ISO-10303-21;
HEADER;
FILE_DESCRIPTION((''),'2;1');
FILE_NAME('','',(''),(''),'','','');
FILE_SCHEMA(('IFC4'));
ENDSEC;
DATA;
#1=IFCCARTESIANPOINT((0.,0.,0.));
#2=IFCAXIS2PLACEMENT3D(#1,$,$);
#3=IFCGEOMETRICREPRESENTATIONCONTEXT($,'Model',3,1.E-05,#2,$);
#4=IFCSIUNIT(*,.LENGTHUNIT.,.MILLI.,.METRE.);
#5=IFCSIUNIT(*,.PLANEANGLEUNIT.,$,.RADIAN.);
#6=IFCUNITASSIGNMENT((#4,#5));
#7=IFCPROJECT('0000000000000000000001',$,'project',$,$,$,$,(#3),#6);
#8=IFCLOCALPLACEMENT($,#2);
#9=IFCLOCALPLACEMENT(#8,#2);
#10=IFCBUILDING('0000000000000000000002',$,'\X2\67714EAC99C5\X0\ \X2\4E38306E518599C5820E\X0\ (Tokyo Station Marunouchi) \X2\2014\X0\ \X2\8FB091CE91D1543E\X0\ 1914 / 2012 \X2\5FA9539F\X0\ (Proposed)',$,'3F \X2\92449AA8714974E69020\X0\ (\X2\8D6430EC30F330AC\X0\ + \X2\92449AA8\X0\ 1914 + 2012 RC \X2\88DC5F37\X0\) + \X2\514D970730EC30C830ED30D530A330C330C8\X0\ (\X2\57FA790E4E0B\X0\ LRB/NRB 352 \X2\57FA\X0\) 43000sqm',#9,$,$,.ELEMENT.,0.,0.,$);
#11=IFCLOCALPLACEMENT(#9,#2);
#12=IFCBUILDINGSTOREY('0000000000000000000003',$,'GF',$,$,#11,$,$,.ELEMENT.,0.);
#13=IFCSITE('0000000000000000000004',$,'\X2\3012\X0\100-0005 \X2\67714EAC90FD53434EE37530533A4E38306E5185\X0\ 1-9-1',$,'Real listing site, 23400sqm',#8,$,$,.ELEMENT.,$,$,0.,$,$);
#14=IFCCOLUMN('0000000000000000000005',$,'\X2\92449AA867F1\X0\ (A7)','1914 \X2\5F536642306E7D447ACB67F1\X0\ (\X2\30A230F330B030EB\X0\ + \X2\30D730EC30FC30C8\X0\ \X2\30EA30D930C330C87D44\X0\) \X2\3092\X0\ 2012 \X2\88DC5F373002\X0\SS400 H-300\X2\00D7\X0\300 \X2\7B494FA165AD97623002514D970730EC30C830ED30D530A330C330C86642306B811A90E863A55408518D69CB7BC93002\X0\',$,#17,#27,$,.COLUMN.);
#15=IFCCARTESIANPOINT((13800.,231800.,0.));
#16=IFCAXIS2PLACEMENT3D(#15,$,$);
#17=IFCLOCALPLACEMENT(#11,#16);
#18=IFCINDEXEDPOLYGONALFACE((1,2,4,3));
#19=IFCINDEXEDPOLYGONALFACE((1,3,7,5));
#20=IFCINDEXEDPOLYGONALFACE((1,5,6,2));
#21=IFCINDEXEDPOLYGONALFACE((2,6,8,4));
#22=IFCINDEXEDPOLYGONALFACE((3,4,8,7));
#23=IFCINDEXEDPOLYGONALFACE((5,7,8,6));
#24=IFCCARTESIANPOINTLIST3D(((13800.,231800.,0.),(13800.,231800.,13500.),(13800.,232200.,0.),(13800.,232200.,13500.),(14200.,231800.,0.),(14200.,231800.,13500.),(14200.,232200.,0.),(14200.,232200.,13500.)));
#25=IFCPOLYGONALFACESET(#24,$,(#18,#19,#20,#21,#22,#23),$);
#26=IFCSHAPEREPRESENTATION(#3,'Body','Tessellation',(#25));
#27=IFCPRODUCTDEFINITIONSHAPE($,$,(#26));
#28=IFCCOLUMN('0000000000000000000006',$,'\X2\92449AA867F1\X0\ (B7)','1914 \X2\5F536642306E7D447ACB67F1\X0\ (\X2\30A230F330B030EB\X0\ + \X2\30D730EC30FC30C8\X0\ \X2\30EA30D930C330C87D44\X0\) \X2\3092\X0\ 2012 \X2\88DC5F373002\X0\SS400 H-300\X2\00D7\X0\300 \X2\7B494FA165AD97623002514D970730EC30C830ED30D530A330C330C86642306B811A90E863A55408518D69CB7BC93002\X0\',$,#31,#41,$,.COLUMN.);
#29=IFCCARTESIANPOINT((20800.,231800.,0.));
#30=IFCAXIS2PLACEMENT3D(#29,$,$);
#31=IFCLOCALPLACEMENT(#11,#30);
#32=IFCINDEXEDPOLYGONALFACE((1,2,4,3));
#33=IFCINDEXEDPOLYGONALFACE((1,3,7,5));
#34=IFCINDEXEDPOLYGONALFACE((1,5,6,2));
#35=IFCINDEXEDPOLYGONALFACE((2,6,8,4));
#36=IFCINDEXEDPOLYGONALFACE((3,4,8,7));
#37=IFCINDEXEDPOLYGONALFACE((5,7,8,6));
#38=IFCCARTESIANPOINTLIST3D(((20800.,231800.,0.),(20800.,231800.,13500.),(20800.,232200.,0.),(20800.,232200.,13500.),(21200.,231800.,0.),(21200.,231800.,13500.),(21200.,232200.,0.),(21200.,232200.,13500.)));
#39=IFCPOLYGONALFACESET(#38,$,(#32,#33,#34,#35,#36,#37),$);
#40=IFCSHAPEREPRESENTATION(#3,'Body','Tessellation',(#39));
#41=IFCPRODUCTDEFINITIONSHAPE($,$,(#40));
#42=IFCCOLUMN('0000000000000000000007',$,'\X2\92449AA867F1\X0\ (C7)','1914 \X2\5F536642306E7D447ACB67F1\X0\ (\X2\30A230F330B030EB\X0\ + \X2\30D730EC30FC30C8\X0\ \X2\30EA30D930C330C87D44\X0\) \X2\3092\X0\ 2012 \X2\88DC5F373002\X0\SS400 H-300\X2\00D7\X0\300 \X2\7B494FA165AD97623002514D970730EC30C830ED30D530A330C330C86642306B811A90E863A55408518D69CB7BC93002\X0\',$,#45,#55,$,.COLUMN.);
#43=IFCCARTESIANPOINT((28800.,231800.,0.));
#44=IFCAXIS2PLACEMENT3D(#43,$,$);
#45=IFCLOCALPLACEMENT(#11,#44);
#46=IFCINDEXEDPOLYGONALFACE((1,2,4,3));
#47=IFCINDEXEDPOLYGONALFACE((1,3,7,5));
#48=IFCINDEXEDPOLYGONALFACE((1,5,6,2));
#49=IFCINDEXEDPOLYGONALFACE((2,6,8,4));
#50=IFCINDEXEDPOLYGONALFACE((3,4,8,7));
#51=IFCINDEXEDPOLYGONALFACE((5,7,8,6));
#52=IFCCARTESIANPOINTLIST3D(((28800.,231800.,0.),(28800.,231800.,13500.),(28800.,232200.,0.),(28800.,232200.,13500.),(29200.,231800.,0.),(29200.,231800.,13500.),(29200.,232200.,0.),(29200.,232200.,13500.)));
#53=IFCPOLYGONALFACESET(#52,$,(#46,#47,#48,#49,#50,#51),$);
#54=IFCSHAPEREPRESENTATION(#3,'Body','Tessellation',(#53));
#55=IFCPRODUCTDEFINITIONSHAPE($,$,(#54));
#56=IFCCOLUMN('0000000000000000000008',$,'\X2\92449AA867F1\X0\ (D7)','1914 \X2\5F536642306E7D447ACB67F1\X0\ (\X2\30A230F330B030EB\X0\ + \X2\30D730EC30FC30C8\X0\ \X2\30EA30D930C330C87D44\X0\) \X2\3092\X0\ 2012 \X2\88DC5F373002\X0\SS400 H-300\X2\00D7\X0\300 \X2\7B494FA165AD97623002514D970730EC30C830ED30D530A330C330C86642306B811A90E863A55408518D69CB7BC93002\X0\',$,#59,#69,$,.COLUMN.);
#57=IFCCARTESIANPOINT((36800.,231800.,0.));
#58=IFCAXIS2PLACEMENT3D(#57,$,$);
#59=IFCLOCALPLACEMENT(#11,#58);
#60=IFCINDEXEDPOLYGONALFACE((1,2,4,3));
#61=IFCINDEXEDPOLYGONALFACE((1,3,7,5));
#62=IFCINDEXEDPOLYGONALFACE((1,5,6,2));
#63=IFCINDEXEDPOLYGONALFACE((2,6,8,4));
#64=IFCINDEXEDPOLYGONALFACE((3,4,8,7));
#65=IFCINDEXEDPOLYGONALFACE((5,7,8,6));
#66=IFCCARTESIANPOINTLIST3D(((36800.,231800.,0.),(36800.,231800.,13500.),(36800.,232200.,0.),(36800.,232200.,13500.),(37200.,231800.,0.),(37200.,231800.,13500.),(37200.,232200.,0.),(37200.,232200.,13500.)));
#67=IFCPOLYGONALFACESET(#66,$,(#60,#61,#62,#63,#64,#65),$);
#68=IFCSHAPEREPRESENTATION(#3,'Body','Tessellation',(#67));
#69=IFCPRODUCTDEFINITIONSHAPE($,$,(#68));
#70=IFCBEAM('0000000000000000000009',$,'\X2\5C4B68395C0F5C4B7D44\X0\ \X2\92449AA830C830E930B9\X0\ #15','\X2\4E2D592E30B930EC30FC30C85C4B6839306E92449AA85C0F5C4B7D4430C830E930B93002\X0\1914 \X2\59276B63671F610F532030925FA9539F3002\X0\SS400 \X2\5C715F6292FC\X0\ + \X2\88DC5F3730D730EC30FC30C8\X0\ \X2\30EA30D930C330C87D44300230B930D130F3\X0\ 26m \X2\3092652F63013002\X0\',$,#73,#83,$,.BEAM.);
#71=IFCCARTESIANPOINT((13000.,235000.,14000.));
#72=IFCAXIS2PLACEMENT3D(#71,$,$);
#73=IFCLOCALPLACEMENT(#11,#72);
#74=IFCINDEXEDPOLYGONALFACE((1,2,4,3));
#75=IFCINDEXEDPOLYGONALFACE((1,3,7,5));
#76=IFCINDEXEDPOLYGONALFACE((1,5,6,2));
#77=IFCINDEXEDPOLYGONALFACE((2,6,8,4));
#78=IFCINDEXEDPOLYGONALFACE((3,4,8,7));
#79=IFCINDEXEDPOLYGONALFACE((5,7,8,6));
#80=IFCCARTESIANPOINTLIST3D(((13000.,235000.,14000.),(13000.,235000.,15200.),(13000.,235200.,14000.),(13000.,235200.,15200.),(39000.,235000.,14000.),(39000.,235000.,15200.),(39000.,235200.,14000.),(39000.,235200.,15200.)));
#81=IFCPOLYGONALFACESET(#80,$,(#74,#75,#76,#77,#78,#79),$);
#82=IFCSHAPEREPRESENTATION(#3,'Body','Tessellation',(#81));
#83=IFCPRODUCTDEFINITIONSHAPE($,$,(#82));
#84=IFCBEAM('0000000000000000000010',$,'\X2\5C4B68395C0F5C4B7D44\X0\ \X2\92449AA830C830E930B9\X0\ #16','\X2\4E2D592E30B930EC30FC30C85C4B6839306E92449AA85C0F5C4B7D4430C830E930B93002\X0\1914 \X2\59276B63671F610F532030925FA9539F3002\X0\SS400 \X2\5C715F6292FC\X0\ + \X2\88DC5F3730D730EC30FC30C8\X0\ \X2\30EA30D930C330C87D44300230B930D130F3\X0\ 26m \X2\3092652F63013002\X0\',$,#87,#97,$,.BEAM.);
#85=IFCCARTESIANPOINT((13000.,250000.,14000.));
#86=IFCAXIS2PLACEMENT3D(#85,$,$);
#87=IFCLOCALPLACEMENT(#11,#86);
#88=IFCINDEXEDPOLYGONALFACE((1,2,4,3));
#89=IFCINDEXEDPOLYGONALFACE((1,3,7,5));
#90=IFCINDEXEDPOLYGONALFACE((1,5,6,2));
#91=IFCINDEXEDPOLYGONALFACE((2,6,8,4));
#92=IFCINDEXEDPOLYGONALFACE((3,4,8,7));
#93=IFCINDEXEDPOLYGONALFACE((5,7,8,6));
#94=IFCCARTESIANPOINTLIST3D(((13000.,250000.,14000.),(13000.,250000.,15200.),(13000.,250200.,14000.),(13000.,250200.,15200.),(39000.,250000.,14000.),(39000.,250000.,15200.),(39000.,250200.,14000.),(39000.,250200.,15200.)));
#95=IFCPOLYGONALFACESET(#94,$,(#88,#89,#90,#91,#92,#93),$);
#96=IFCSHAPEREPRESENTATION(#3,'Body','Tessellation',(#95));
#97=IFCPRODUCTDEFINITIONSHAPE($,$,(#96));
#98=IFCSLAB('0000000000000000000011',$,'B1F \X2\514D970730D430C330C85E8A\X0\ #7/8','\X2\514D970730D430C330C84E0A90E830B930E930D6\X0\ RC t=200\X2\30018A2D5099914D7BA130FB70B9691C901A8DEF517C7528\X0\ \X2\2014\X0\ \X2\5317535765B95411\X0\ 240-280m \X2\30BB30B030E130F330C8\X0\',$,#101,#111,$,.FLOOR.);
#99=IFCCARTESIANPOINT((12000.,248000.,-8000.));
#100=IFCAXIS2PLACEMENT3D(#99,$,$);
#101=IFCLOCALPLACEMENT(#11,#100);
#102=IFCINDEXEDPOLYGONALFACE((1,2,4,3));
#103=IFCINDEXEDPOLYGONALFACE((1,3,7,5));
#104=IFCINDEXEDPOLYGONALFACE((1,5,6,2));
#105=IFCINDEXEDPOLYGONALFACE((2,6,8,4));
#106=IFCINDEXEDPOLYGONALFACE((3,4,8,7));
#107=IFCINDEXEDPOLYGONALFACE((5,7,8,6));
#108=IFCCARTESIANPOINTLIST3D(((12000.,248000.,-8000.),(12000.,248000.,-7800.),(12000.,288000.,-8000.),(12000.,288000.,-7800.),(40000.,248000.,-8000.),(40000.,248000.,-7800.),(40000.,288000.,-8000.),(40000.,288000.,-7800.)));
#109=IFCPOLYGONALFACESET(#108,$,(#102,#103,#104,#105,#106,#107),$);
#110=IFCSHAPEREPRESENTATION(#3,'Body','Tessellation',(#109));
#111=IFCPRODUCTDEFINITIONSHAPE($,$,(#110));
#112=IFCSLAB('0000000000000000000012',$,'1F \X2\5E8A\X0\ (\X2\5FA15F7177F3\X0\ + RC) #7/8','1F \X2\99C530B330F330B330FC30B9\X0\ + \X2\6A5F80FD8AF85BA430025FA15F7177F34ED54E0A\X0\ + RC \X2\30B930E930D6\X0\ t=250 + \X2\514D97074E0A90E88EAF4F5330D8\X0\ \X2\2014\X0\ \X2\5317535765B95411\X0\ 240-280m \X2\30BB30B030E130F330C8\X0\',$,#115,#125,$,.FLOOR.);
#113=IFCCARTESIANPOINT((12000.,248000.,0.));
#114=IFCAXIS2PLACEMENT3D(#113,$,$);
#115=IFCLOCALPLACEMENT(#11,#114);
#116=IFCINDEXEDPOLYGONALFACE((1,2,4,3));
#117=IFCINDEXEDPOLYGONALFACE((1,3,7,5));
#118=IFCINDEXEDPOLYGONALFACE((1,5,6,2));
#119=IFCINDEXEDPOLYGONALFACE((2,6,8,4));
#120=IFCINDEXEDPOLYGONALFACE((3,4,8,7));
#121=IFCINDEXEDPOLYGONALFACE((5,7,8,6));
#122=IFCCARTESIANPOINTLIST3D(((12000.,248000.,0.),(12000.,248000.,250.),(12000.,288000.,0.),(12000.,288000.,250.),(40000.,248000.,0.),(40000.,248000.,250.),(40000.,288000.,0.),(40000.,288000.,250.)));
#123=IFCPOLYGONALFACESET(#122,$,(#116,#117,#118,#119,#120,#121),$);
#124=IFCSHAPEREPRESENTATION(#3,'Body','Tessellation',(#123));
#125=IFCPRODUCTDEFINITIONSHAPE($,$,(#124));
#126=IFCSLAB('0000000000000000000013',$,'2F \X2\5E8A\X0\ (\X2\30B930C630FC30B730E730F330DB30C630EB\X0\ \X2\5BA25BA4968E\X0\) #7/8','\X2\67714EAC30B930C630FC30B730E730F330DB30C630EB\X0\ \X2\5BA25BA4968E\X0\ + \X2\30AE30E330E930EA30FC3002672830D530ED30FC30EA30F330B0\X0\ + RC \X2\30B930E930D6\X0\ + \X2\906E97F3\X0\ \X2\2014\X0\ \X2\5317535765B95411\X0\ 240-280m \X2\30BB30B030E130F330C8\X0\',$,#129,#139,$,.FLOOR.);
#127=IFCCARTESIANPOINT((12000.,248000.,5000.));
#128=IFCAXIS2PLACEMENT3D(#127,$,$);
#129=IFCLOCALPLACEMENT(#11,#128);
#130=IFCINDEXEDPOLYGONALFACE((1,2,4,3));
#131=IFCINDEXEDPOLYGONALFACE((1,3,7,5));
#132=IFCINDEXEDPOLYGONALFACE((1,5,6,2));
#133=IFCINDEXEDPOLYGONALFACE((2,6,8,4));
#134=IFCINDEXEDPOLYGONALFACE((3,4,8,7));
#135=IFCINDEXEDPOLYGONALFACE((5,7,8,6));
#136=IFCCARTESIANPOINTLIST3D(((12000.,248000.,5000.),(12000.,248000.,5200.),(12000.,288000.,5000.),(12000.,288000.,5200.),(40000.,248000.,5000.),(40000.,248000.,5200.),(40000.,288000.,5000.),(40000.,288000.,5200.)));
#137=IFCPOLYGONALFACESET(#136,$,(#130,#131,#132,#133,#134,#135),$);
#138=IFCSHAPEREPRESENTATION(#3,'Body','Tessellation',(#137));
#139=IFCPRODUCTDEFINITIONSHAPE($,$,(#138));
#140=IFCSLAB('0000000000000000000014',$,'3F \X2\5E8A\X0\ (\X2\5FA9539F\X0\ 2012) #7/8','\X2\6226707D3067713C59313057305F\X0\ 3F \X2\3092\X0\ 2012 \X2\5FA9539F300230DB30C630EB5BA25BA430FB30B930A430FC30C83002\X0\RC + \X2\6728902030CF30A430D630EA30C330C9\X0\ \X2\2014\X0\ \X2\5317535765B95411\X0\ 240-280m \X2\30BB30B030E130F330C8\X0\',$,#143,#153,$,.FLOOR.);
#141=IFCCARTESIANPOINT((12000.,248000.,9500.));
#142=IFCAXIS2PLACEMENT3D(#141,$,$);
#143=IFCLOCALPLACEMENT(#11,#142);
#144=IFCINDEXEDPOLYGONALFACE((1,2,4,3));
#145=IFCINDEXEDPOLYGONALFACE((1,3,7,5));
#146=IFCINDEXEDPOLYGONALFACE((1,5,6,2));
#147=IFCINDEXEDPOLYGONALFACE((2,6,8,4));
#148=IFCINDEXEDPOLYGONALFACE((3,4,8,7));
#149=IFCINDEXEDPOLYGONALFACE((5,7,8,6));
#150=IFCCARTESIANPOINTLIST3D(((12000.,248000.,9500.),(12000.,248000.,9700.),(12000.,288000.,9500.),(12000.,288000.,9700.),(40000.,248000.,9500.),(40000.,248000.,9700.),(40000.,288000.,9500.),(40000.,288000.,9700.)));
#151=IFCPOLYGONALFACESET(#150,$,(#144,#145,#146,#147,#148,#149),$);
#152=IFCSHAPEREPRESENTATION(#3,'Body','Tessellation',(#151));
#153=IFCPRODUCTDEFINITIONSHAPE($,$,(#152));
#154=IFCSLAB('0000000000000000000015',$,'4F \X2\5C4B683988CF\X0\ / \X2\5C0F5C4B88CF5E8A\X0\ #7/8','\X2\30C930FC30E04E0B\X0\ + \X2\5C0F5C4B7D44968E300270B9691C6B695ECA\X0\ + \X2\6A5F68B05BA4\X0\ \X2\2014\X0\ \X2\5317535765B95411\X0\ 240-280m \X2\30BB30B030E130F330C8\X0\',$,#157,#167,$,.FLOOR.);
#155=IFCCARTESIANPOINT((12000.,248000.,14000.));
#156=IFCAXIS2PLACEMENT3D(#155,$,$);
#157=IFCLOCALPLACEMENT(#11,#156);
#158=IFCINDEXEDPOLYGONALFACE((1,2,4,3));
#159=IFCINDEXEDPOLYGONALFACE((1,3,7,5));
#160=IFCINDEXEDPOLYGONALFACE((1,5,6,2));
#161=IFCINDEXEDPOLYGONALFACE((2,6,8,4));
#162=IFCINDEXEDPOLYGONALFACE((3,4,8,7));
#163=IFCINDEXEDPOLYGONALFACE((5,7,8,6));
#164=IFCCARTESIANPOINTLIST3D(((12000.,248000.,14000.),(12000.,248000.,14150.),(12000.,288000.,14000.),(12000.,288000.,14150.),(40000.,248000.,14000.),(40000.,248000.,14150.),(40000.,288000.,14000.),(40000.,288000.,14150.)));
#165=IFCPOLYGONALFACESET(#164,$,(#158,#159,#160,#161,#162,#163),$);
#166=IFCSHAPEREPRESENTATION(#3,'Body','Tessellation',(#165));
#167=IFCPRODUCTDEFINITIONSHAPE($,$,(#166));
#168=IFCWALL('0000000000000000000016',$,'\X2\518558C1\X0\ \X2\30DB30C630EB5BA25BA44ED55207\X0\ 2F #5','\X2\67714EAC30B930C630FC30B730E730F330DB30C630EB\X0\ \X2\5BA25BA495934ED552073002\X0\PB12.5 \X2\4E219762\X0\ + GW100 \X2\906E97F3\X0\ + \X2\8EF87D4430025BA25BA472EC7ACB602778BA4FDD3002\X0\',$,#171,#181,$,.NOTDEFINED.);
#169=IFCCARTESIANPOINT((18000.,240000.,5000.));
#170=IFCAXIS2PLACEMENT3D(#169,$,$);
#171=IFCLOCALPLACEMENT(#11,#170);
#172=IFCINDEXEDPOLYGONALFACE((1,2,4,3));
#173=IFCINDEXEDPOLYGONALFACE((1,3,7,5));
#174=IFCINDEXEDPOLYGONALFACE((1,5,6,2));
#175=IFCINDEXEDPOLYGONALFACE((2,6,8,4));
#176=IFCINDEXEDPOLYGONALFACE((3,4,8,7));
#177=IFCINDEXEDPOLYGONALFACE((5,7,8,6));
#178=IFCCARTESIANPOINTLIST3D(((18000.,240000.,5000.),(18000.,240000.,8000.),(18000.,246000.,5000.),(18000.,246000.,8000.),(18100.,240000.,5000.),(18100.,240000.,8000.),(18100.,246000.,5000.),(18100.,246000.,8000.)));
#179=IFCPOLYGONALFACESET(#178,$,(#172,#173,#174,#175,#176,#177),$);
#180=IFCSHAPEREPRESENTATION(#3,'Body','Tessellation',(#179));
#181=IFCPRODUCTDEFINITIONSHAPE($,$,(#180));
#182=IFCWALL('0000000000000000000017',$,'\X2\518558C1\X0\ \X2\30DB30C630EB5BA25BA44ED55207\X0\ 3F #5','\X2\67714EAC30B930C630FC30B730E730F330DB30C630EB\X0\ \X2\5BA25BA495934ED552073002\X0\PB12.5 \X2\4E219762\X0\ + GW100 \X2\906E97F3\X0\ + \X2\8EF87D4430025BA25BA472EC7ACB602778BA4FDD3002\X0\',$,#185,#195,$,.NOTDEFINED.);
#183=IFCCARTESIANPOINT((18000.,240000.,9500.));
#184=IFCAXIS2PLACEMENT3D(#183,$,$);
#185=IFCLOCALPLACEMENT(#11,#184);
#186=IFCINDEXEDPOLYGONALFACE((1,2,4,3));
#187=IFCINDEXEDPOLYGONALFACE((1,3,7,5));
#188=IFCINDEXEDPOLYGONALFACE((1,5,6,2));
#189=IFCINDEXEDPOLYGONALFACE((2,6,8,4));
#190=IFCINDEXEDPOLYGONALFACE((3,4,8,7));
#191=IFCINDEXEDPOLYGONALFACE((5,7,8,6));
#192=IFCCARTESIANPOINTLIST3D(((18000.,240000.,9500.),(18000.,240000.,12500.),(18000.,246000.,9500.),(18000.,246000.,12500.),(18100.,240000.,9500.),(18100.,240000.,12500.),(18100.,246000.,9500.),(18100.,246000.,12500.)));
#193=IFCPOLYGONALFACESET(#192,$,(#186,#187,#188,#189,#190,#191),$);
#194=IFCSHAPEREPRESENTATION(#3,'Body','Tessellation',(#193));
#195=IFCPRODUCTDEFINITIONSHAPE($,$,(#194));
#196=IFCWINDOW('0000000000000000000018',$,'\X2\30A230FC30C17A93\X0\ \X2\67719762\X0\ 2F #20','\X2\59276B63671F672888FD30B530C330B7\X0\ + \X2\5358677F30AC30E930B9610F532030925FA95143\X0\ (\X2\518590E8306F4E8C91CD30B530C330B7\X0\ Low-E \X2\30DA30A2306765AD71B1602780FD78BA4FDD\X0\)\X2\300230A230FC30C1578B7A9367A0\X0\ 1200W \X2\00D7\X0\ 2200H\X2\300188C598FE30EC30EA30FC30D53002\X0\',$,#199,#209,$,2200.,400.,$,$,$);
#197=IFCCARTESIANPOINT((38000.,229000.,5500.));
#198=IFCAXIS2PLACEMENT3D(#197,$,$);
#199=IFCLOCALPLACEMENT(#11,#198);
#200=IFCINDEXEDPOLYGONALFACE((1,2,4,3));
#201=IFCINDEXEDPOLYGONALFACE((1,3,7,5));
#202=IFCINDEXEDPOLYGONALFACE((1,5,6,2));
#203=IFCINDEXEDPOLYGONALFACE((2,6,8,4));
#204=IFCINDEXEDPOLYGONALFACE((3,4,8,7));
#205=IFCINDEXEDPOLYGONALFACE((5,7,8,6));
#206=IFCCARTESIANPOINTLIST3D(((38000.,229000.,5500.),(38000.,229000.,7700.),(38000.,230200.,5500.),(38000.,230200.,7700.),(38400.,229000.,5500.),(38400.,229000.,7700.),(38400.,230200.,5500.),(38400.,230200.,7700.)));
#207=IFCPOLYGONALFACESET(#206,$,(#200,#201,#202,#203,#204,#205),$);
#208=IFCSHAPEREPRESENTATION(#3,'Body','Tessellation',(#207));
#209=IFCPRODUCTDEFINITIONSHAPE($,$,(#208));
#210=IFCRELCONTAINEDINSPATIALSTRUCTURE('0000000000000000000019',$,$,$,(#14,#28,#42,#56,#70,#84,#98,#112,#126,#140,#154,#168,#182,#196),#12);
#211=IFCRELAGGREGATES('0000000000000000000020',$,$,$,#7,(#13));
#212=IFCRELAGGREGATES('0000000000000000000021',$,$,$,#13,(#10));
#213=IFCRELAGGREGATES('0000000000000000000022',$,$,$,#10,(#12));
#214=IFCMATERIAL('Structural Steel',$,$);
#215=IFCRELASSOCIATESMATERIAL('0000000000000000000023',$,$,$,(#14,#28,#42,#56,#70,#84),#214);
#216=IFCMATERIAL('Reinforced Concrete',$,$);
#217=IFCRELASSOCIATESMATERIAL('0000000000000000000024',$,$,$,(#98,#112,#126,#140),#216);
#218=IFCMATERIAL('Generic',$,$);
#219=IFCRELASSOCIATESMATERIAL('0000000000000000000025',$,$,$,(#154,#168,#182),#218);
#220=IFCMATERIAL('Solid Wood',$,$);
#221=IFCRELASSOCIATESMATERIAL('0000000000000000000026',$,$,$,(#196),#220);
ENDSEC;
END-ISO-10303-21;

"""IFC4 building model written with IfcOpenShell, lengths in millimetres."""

from ifc_helpers import new_model, si_unit, frame, frame_2d, origin, place, context, project, spatial, rectangle, extrude, material, element, save


model = new_model("IFC4")

# Units and contexts
model_context = context("Model", 3, precision=1e-05, world=origin())
ifc_project = project(units=[si_unit("LENGTHUNIT", "METRE", prefix="MILLI"), si_unit("PLANEANGLEUNIT", "RADIAN")], contexts=[model_context])

# Site, building, storey
site_placement = place(None, origin())
site = spatial("IfcSite", under=ifc_project, at=site_placement, Name="〒100-0005 東京都千代田区丸の内 1-9-1", ObjectType="Real listing site, 23400sqm", CompositionType="ELEMENT", RefElevation=0.0)
building_placement = place(site_placement, origin())
building = spatial("IfcBuilding", under=site, at=building_placement, Name="東京駅 丸の内駅舎 (Tokyo Station Marunouchi) — 辰野金吾 1914 / 2012 復原 (Proposed)", ObjectType="3F 鉄骨煉瓦造 (赤レンガ + 鉄骨 1914 + 2012 RC 補強) + 免震レトロフィット (基礎下 LRB/NRB 352 基) 43000sqm", CompositionType="ELEMENT", ElevationOfRefHeight=0.0, ElevationOfTerrain=0.0)
storey_placement = place(building_placement, origin())
storey = spatial("IfcBuildingStorey", under=building, at=storey_placement, Name="GF", CompositionType="ELEMENT", Elevation=0.0)

# Columns
ifc_material_1 = material(Name="Structural Steel")
column_1_placement = place(storey_placement, frame((13800.0, 231800.0, 0.0)))
element("IfcColumn", 1, at=column_1_placement, inside=storey, material=ifc_material_1, Name="鉄骨柱 (A7)", Description="1914 当時の組立柱 (アングル + プレート リベット組) を 2012 補強。SS400 H-300×300 等価断面。免震レトロフィット時に脚部接合再構築。", PredefinedType="COLUMN", context=model_context, shape_type="SweptSolid", body=[
    extrude(rectangle(XDim=400.0, YDim=400.0, at=frame_2d((200.0, 200.0))), frame((13800.0, 231800.0, 0.0)), (0.0, 0.0, 1.0), 13500.0),
])
column_2_placement = place(storey_placement, frame((20800.0, 231800.0, 0.0)))
element("IfcColumn", 2, at=column_2_placement, inside=storey, material=ifc_material_1, Name="鉄骨柱 (B7)", Description="1914 当時の組立柱 (アングル + プレート リベット組) を 2012 補強。SS400 H-300×300 等価断面。免震レトロフィット時に脚部接合再構築。", PredefinedType="COLUMN", context=model_context, shape_type="SweptSolid", body=[
    extrude(rectangle(XDim=400.0, YDim=400.0, at=frame_2d((200.0, 200.0))), frame((20800.0, 231800.0, 0.0)), (0.0, 0.0, 1.0), 13500.0),
])
column_3_placement = place(storey_placement, frame((28800.0, 231800.0, 0.0)))
element("IfcColumn", 3, at=column_3_placement, inside=storey, material=ifc_material_1, Name="鉄骨柱 (C7)", Description="1914 当時の組立柱 (アングル + プレート リベット組) を 2012 補強。SS400 H-300×300 等価断面。免震レトロフィット時に脚部接合再構築。", PredefinedType="COLUMN", context=model_context, shape_type="SweptSolid", body=[
    extrude(rectangle(XDim=400.0, YDim=400.0, at=frame_2d((200.0, 200.0))), frame((28800.0, 231800.0, 0.0)), (0.0, 0.0, 1.0), 13500.0),
])
column_4_placement = place(storey_placement, frame((36800.0, 231800.0, 0.0)))
element("IfcColumn", 4, at=column_4_placement, inside=storey, material=ifc_material_1, Name="鉄骨柱 (D7)", Description="1914 当時の組立柱 (アングル + プレート リベット組) を 2012 補強。SS400 H-300×300 等価断面。免震レトロフィット時に脚部接合再構築。", PredefinedType="COLUMN", context=model_context, shape_type="SweptSolid", body=[
    extrude(rectangle(XDim=400.0, YDim=400.0, at=frame_2d((200.0, 200.0))), frame((36800.0, 231800.0, 0.0)), (0.0, 0.0, 1.0), 13500.0),
])

# Beams
beam_1_placement = place(storey_placement, frame((13000.0, 235000.0, 14000.0)))
element("IfcBeam", 5, at=beam_1_placement, inside=storey, material=ifc_material_1, Name="屋根小屋組 鉄骨トラス #15", Description="中央スレート屋根の鉄骨小屋組トラス。1914 大正期意匠を復原。SS400 山形鋼 + 補強プレート リベット組。スパン 26m を支持。", PredefinedType="BEAM", context=model_context, shape_type="SweptSolid", body=[
    extrude(rectangle(XDim=26000.0, YDim=200.0, at=frame_2d((13000.0, 100.0))), frame((13000.0, 235000.0, 14000.0)), (0.0, 0.0, 1.0), 1200.0),
])
beam_2_placement = place(storey_placement, frame((13000.0, 250000.0, 14000.0)))
element("IfcBeam", 6, at=beam_2_placement, inside=storey, material=ifc_material_1, Name="屋根小屋組 鉄骨トラス #16", Description="中央スレート屋根の鉄骨小屋組トラス。1914 大正期意匠を復原。SS400 山形鋼 + 補強プレート リベット組。スパン 26m を支持。", PredefinedType="BEAM", context=model_context, shape_type="SweptSolid", body=[
    extrude(rectangle(XDim=26000.0, YDim=200.0, at=frame_2d((13000.0, 100.0))), frame((13000.0, 250000.0, 14000.0)), (0.0, 0.0, 1.0), 1200.0),
])

# Slabs
ifc_material_2 = material(Name="Reinforced Concrete")
slab_1_placement = place(storey_placement, frame((12000.0, 248000.0, -8000.0)))
element("IfcSlab", 7, at=slab_1_placement, inside=storey, material=ifc_material_2, Name="B1F 免震ピット床 #7/8", Description="免震ピット上部スラブ RC t=200、設備配管・点検通路兼用 — 北南方向 240-280m セグメント", PredefinedType="FLOOR", context=model_context, shape_type="SweptSolid", body=[
    extrude(rectangle(XDim=28000.0, YDim=40000.0, at=frame_2d((14000.0, 20000.0))), frame((12000.0, 248000.0, -8000.0)), (0.0, 0.0, 1.0), 200.0),
])
slab_2_placement = place(storey_placement, frame((12000.0, 248000.0, 0.0)))
element("IfcSlab", 8, at=slab_2_placement, inside=storey, material=ifc_material_2, Name="1F 床 (御影石 + RC) #7/8", Description="1F 駅コンコース + 機能諸室。御影石仕上 + RC スラブ t=250 + 免震上部躯体ヘ — 北南方向 240-280m セグメント", PredefinedType="FLOOR", context=model_context, shape_type="SweptSolid", body=[
    extrude(rectangle(XDim=28000.0, YDim=40000.0, at=frame_2d((14000.0, 20000.0))), frame((12000.0, 248000.0, 0.0)), (0.0, 0.0, 1.0), 250.0),
])
slab_3_placement = place(storey_placement, frame((12000.0, 248000.0, 5000.0)))
element("IfcSlab", 9, at=slab_3_placement, inside=storey, material=ifc_material_2, Name="2F 床 (ステーションホテル 客室階) #7/8", Description="東京ステーションホテル 客室階 + ギャラリー。木フローリング + RC スラブ + 遮音 — 北南方向 240-280m セグメント", PredefinedType="FLOOR", context=model_context, shape_type="SweptSolid", body=[
    extrude(rectangle(XDim=28000.0, YDim=40000.0, at=frame_2d((14000.0, 20000.0))), frame((12000.0, 248000.0, 5000.0)), (0.0, 0.0, 1.0), 200.0),
])
slab_4_placement = place(storey_placement, frame((12000.0, 248000.0, 9500.0)))
element("IfcSlab", 10, at=slab_4_placement, inside=storey, material=ifc_material_2, Name="3F 床 (復原 2012) #7/8", Description="戦災で焼失した 3F を 2012 復原。ホテル客室・スイート。RC + 木造ハイブリッド — 北南方向 240-280m セグメント", PredefinedType="FLOOR", context=model_context, shape_type="SweptSolid", body=[
    extrude(rectangle(XDim=28000.0, YDim=40000.0, at=frame_2d((14000.0, 20000.0))), frame((12000.0, 248000.0, 9500.0)), (0.0, 0.0, 1.0), 200.0),
])
ifc_material_3 = material(Name="Generic")
slab_5_placement = place(storey_placement, frame((12000.0, 248000.0, 14000.0)))
element("IfcSlab", 11, at=slab_5_placement, inside=storey, material=ifc_material_3, Name="4F 屋根裏 / 小屋裏床 #7/8", Description="ドーム下 + 小屋組階。点検歩廊 + 機械室 — 北南方向 240-280m セグメント", PredefinedType="FLOOR", context=model_context, shape_type="SweptSolid", body=[
    extrude(rectangle(XDim=28000.0, YDim=40000.0, at=frame_2d((14000.0, 20000.0))), frame((12000.0, 248000.0, 14000.0)), (0.0, 0.0, 1.0), 150.0),
])

# Walls
wall_1_placement = place(storey_placement, frame((18000.0, 240000.0, 5000.0)))
element("IfcWall", 12, at=wall_1_placement, inside=storey, material=ifc_material_3, Name="内壁 ホテル客室仕切 2F #5", Description="東京ステーションホテル 客室間仕切。PB12.5 両面 + GW100 遮音 + 軸組。客室独立性確保。", PredefinedType="NOTDEFINED", context=model_context, shape_type="SweptSolid", body=[
    extrude(rectangle(XDim=100.0, YDim=6000.0, at=frame_2d((50.0, 3000.0))), frame((18000.0, 240000.0, 5000.0)), (0.0, 0.0, 1.0), 3000.0),
])
wall_2_placement = place(storey_placement, frame((18000.0, 240000.0, 9500.0)))
element("IfcWall", 13, at=wall_2_placement, inside=storey, material=ifc_material_3, Name="内壁 ホテル客室仕切 3F #5", Description="東京ステーションホテル 客室間仕切。PB12.5 両面 + GW100 遮音 + 軸組。客室独立性確保。", PredefinedType="NOTDEFINED", context=model_context, shape_type="SweptSolid", body=[
    extrude(rectangle(XDim=100.0, YDim=6000.0, at=frame_2d((50.0, 3000.0))), frame((18000.0, 240000.0, 9500.0)), (0.0, 0.0, 1.0), 3000.0),
])

# Window
ifc_material_4 = material(Name="Solid Wood")
window_1_placement = place(storey_placement, frame((38000.0, 229000.0, 5500.0)))
element("IfcWindow", 14, at=window_1_placement, inside=storey, material=ifc_material_4, Name="アーチ窓 東面 2F #20", Description="大正期木製サッシ + 単板ガラス意匠を復元 (内部は二重サッシ Low-E ペアで断熱性能確保)。アーチ型窓枠 1200W × 2200H、装飾レリーフ。", OverallHeight=2200.0, OverallWidth=400.0, context=model_context, shape_type="SweptSolid", body=[
    extrude(rectangle(XDim=400.0, YDim=1200.0, at=frame_2d((200.0, 600.0))), frame((38000.0, 229000.0, 5500.0)), (0.0, 0.0, 1.0), 2200.0),
])

save(model, "model.ifc")
